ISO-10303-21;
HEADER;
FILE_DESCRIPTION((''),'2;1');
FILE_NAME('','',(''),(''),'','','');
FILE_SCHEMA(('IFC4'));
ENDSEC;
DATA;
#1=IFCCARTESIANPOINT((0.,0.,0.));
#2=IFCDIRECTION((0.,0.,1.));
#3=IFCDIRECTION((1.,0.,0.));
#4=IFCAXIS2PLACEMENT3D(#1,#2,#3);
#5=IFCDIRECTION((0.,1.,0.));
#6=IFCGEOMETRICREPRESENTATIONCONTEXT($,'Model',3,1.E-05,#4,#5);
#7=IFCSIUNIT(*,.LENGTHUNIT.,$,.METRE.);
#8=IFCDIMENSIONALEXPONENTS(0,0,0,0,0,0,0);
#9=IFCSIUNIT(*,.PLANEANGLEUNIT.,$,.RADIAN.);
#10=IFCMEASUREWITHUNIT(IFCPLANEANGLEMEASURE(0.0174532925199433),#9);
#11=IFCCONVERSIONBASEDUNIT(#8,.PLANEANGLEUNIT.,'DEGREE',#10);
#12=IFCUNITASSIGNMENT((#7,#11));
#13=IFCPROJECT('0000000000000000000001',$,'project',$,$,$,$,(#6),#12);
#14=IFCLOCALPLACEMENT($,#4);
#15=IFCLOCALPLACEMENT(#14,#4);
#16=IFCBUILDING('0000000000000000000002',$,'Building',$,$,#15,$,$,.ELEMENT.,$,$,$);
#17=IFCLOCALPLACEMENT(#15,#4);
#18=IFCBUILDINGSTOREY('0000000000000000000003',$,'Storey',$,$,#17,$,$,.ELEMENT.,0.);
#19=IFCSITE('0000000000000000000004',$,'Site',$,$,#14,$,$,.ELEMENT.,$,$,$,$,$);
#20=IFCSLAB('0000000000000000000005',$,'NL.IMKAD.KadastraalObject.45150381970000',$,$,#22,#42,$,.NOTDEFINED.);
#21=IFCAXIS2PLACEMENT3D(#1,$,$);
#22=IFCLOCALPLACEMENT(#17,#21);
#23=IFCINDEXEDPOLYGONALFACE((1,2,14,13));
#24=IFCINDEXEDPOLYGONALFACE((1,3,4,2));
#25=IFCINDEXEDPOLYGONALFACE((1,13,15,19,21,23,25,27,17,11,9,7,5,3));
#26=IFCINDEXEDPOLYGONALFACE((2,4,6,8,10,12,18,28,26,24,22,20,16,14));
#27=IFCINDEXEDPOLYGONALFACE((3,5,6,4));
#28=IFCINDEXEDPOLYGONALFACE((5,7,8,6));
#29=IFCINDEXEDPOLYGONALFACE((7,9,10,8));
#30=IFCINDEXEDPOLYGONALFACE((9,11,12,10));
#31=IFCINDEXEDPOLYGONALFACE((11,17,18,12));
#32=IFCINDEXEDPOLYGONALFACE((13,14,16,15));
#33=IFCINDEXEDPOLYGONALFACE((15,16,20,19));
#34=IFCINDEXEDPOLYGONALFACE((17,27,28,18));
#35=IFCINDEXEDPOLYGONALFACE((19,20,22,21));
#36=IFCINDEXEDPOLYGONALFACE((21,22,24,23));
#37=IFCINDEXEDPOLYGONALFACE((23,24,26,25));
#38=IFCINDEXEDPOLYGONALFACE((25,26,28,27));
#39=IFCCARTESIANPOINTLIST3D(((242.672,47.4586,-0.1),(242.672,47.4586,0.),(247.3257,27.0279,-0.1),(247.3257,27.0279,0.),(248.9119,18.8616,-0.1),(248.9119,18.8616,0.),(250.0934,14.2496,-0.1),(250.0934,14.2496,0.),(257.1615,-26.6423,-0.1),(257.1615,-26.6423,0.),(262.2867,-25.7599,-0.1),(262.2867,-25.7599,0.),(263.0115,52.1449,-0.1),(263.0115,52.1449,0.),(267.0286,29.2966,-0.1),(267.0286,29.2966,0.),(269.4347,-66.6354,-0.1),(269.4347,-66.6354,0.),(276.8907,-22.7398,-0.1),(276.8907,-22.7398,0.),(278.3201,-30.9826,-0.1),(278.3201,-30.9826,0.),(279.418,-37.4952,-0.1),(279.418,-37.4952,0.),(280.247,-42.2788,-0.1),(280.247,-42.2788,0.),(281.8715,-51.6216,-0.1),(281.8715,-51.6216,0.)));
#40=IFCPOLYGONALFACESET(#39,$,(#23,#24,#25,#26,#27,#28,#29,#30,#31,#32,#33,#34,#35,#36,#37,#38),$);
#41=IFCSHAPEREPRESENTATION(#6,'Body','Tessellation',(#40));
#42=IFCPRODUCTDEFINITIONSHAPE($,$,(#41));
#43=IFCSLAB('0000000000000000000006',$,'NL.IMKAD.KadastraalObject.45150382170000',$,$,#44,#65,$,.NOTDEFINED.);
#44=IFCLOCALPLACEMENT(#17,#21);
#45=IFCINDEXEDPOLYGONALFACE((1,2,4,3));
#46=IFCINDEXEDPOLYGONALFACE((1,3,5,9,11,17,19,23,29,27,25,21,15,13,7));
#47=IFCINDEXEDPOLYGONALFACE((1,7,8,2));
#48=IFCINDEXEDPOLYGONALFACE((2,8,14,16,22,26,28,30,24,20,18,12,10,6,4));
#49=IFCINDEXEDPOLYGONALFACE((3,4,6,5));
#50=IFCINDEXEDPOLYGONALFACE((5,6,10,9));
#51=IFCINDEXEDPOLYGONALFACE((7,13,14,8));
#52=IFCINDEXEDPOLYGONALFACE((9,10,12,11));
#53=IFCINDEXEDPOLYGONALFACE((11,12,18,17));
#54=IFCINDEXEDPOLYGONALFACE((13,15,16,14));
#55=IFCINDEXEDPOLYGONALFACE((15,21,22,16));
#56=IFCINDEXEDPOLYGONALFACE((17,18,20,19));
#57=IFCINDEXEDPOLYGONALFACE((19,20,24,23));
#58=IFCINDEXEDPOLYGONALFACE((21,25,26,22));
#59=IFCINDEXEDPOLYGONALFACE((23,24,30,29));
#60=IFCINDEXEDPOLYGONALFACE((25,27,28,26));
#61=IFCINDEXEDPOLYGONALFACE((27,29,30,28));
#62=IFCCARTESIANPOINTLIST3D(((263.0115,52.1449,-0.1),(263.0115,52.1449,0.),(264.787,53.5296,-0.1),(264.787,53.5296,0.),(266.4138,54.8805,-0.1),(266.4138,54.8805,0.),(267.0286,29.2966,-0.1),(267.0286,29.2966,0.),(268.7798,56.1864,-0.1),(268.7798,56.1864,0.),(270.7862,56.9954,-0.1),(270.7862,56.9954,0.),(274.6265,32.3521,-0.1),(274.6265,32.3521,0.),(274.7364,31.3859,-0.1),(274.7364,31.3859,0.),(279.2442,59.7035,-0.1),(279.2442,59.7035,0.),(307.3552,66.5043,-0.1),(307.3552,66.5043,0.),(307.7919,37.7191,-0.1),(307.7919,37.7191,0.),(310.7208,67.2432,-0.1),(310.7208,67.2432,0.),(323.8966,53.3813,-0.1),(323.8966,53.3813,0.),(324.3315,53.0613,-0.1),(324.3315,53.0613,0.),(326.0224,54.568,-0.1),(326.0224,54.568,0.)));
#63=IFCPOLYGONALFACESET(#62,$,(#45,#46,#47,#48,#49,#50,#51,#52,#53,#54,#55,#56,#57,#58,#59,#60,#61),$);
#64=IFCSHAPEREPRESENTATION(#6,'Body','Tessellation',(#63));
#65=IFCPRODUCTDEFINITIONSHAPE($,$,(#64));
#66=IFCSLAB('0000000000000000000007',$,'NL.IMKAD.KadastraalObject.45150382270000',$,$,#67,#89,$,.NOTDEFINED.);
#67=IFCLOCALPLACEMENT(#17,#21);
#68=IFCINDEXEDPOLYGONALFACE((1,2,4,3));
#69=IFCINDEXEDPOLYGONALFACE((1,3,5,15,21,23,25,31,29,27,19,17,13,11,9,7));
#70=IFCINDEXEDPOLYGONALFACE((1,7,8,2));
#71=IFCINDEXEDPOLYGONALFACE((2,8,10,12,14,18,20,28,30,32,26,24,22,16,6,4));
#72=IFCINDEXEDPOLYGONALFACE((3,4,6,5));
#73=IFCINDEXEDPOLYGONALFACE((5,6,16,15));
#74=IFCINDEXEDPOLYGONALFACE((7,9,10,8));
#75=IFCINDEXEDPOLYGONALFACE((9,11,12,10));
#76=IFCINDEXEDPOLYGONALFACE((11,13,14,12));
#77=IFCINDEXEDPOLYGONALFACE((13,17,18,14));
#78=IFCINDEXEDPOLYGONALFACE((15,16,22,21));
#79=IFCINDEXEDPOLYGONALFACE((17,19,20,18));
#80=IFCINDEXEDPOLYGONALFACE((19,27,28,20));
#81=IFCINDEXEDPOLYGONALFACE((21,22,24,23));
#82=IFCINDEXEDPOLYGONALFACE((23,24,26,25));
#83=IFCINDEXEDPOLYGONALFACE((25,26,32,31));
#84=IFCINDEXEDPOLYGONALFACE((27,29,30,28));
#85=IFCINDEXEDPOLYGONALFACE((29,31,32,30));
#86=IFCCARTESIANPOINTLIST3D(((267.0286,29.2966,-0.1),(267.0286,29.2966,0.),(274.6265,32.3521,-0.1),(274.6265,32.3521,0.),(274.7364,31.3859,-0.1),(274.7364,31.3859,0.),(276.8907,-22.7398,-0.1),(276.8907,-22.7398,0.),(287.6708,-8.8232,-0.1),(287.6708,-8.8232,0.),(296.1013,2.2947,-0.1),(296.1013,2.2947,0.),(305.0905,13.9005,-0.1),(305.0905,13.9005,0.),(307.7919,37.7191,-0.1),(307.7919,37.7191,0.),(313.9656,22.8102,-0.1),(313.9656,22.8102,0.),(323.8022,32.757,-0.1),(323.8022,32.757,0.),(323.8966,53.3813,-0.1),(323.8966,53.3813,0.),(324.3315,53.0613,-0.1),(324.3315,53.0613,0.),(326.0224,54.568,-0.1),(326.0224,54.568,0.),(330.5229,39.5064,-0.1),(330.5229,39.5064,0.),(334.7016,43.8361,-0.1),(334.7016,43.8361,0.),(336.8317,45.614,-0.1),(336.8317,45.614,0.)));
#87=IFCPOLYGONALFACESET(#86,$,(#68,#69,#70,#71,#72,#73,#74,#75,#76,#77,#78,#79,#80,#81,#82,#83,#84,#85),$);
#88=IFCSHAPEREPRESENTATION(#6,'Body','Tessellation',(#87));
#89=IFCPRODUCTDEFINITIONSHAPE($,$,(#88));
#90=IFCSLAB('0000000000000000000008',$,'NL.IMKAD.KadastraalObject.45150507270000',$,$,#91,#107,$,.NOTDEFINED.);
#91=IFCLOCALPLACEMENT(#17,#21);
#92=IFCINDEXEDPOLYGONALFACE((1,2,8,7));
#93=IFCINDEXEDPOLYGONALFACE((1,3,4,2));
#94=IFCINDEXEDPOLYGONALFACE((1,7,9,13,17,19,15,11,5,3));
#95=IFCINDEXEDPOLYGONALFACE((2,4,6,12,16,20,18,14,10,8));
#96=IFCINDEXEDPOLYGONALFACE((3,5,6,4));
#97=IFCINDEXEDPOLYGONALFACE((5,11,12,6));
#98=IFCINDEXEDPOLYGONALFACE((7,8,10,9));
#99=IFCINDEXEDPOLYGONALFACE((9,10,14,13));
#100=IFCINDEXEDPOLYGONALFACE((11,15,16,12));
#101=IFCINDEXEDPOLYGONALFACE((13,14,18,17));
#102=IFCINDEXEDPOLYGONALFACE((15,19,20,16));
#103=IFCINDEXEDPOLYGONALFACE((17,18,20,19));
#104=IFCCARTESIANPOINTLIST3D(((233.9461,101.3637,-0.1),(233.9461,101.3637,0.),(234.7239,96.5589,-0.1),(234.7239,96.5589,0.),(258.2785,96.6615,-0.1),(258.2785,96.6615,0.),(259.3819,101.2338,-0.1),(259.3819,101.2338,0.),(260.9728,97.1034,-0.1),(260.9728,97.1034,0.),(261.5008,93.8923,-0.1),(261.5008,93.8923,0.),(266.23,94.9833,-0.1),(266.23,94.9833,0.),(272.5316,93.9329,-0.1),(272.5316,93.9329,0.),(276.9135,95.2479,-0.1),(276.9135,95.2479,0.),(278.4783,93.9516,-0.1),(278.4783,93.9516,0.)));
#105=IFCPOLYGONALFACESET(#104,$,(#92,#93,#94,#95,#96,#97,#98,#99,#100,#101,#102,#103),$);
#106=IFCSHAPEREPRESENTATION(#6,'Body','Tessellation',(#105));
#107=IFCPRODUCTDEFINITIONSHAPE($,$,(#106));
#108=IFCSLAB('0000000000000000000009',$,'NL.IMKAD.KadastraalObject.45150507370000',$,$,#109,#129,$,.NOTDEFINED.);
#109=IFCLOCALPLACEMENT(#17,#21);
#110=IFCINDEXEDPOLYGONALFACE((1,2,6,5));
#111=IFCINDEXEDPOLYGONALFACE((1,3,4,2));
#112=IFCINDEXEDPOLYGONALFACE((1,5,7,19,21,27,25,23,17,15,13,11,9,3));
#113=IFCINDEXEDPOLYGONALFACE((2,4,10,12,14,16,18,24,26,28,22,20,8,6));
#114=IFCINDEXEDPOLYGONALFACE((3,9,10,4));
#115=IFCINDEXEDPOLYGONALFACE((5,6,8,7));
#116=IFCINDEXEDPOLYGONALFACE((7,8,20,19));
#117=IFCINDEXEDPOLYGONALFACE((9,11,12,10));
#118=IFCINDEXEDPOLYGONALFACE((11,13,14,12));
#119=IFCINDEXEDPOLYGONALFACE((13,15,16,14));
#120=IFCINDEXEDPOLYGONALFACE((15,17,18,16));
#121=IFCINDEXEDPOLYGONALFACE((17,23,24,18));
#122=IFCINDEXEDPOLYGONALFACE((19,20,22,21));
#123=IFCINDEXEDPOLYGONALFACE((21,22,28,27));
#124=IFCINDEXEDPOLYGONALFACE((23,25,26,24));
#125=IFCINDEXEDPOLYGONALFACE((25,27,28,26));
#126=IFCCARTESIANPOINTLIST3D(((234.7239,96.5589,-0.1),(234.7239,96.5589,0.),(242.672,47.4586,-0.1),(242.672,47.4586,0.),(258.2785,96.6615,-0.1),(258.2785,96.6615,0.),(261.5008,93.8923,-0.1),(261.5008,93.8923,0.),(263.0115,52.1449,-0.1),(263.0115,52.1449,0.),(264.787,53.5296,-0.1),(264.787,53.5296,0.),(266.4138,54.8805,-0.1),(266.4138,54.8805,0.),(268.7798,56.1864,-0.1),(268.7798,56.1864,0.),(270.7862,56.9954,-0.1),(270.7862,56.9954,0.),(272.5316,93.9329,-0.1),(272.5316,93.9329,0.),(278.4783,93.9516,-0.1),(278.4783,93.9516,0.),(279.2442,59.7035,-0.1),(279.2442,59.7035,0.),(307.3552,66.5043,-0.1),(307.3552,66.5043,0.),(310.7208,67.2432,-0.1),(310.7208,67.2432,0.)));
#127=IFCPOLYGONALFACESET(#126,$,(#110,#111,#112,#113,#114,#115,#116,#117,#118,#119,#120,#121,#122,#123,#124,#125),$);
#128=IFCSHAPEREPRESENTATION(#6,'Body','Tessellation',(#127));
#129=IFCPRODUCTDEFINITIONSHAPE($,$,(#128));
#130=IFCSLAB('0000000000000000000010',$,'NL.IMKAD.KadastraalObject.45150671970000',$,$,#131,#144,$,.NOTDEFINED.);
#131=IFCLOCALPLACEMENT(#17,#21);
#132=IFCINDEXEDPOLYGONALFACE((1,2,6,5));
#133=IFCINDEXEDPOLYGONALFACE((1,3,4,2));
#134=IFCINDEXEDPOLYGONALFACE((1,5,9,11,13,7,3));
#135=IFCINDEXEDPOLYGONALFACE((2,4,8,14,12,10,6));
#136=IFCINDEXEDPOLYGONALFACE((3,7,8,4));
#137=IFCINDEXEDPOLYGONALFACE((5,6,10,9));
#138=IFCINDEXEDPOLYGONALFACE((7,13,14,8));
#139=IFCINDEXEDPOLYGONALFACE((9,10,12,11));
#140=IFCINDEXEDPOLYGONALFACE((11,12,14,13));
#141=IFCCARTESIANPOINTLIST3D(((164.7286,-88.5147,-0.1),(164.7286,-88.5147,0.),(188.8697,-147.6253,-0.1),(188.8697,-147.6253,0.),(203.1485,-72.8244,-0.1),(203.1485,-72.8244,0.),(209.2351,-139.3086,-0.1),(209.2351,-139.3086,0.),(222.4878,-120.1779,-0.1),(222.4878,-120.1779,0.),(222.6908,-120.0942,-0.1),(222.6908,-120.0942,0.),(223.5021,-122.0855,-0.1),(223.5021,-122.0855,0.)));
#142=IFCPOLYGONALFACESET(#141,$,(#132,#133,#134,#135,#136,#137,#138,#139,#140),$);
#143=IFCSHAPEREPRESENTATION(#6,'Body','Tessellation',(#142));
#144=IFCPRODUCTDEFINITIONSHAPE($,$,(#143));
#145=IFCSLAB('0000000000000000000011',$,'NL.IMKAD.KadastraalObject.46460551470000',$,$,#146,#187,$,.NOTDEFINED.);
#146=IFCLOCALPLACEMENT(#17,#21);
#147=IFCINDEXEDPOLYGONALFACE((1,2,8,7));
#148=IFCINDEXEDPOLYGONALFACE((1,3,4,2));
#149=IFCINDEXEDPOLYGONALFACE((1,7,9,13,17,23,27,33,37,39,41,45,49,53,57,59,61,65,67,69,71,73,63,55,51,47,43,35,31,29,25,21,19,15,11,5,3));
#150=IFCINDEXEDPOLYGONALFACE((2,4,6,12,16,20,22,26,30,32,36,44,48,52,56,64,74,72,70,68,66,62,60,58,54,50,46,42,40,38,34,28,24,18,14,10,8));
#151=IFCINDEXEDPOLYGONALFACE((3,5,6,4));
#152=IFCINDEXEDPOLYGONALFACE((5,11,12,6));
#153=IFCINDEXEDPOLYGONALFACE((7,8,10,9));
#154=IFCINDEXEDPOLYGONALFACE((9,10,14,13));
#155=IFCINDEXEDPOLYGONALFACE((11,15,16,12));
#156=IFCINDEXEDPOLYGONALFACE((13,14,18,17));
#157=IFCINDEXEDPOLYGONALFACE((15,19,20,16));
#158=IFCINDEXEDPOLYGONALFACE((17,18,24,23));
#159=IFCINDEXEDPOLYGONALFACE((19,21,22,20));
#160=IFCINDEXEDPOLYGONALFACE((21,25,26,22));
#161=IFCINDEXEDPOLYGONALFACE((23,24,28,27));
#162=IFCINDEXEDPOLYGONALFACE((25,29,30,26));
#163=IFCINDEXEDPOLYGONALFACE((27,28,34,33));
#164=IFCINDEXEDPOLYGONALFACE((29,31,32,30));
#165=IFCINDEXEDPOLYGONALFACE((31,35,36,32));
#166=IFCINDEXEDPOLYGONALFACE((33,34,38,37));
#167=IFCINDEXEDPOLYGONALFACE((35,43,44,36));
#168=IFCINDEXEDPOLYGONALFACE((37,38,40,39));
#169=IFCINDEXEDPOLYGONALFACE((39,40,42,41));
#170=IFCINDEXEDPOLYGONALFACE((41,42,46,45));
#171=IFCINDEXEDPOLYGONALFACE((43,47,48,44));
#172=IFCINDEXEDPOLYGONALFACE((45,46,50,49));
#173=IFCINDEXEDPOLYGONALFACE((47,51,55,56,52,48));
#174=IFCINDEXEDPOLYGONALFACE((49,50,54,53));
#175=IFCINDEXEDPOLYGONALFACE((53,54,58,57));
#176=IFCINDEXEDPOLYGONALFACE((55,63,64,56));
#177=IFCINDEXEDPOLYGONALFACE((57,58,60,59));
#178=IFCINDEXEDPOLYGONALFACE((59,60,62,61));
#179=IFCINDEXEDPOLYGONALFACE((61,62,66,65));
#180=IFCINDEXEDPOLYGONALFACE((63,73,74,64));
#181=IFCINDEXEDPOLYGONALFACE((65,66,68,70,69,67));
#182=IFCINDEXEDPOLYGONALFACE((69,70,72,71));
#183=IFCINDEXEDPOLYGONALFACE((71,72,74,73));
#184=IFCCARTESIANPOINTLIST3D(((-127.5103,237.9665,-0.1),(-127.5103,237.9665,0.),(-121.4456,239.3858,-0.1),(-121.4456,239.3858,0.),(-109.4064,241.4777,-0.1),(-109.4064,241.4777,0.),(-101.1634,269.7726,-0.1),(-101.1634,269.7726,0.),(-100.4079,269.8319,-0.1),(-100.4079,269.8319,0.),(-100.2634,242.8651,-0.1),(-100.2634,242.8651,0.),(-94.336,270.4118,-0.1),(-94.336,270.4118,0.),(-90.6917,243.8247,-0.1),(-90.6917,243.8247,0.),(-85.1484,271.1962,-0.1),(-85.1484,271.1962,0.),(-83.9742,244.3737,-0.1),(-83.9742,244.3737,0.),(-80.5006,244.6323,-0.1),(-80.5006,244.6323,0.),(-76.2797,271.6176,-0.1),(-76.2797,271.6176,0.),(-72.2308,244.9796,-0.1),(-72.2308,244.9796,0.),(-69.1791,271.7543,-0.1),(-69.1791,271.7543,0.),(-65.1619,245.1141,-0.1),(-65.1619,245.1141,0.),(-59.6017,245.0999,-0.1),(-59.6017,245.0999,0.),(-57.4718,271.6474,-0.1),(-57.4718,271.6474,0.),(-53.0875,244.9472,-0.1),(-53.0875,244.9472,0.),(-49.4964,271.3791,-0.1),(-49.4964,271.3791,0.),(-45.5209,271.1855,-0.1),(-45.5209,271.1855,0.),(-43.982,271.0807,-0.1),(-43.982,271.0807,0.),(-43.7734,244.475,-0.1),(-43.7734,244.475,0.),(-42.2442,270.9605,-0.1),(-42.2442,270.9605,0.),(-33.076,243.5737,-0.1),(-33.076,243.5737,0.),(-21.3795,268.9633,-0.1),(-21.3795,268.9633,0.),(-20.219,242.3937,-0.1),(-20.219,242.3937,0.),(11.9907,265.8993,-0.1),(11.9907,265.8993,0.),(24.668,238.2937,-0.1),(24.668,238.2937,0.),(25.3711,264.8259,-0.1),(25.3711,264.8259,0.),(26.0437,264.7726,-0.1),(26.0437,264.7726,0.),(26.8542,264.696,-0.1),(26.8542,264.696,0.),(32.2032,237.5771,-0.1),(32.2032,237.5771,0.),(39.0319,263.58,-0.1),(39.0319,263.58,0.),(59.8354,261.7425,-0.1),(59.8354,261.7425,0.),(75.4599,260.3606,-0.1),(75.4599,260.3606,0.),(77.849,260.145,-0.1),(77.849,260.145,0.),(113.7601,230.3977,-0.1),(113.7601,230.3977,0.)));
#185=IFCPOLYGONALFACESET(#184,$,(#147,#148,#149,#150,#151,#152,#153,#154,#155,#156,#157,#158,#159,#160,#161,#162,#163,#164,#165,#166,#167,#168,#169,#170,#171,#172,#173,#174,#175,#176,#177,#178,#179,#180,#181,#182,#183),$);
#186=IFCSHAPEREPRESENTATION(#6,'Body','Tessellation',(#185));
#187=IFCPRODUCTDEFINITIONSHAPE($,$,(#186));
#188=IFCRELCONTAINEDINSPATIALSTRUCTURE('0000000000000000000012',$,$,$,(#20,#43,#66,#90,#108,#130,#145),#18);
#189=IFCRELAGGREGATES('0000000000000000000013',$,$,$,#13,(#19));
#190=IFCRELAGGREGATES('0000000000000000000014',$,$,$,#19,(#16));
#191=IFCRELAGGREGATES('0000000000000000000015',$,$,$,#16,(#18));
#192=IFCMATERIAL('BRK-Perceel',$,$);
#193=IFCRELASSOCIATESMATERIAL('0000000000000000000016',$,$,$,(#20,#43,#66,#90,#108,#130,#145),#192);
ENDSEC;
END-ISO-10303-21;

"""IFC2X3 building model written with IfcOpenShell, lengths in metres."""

from ifc_helpers import new_model, entity, si_unit, converted_unit, direction, frame, origin_with_axes, place, context, project, spatial, polyline, outline, extrude, material, element, save


model = new_model("IFC2X3")

# Units and contexts
model_context = context("Model", 3, precision=1e-05, world=origin_with_axes(), true_north=direction((0.0, 1.0, 0.0)))
ifc_project = project(units=[si_unit("LENGTHUNIT", "METRE"), converted_unit("PLANEANGLEUNIT", "DEGREE", entity("IfcPlaneAngleMeasure", 0.0174532925199433), si_unit("PLANEANGLEUNIT", "RADIAN"), dimensions=[0, 0, 0, 0, 0, 0, 0])], contexts=[model_context])

# Site, building, storey
site_placement = place(None, origin_with_axes())
site = spatial("IfcSite", under=ifc_project, at=site_placement, Name="Site", CompositionType="ELEMENT")
building_placement = place(site_placement, origin_with_axes())
building = spatial("IfcBuilding", under=site, at=building_placement, Name="Building", CompositionType="ELEMENT")
storey_placement = place(building_placement, origin_with_axes())
storey = spatial("IfcBuildingStorey", under=building, at=storey_placement, Name="Storey", CompositionType="ELEMENT", Elevation=0.0)

# Slabs
ifc_material = material(Name="BRK-Perceel")
slab_1_placement = place(storey_placement, frame((0.0, 0.0, -0.1), z_axis=(0.0, 0.0, 1.0), x_axis=(1.0, 0.0, 0.0)))
element("IfcSlab", 1, at=slab_1_placement, inside=storey, material=ifc_material, Name="NL.IMKAD.KadastraalObject.45150381970000", PredefinedType="NOTDEFINED", context=model_context, shape_type="SweptSolid", body=[
    extrude(outline(polyline([(262.2867, -25.7599), (257.1615, -26.6423), (250.0934, 14.2496), (248.9119, 18.8616), (247.3257, 27.0279), (242.672, 47.4586), (263.0115, 52.1449), (267.0286, 29.2966), (276.8907, -22.7398), (278.3201, -30.9826), (279.418, -37.4952), (280.247, -42.2788), (281.8715, -51.6216), (269.4347, -66.6354), (262.2867, -25.7599)])), origin_with_axes(), (0.0, 0.0, 1.0), 0.1),
])
slab_2_placement = place(storey_placement, frame((0.0, 0.0, -0.1), z_axis=(0.0, 0.0, 1.0), x_axis=(1.0, 0.0, 0.0)))
element("IfcSlab", 2, at=slab_2_placement, inside=storey, material=ifc_material, Name="NL.IMKAD.KadastraalObject.45150382170000", PredefinedType="NOTDEFINED", context=model_context, shape_type="SweptSolid", body=[
    extrude(outline(polyline([(324.3315, 53.0613), (323.8966, 53.3813), (307.7919, 37.7191), (274.7364, 31.3859), (274.6265, 32.3521), (267.0286, 29.2966), (263.0115, 52.1449), (264.787, 53.5296), (266.4138, 54.8805), (268.7798, 56.1864), (270.7862, 56.9954), (279.2442, 59.7035), (307.3552, 66.5043), (310.7208, 67.2432), (326.0224, 54.568), (324.3315, 53.0613)])), origin_with_axes(), (0.0, 0.0, 1.0), 0.1),
])
slab_3_placement = place(storey_placement, frame((0.0, 0.0, -0.1), z_axis=(0.0, 0.0, 1.0), x_axis=(1.0, 0.0, 0.0)))
element("IfcSlab", 3, at=slab_3_placement, inside=storey, material=ifc_material, Name="NL.IMKAD.KadastraalObject.45150382270000", PredefinedType="NOTDEFINED", context=model_context, shape_type="SweptSolid", body=[
    extrude(outline(polyline([(334.7016, 43.8361), (330.5229, 39.5064), (323.8022, 32.757), (313.9656, 22.8102), (305.0905, 13.9005), (296.1013, 2.2947), (287.6708, -8.8232), (276.8907, -22.7398), (267.0286, 29.2966), (274.6265, 32.3521), (274.7364, 31.3859), (307.7919, 37.7191), (323.8966, 53.3813), (324.3315, 53.0613), (326.0224, 54.568), (336.8317, 45.614), (334.7016, 43.8361)])), origin_with_axes(), (0.0, 0.0, 1.0), 0.1),
])
slab_4_placement = place(storey_placement, frame((0.0, 0.0, -0.1), z_axis=(0.0, 0.0, 1.0), x_axis=(1.0, 0.0, 0.0)))
element("IfcSlab", 4, at=slab_4_placement, inside=storey, material=ifc_material, Name="NL.IMKAD.KadastraalObject.45150507270000", PredefinedType="NOTDEFINED", context=model_context, shape_type="SweptSolid", body=[
    extrude(outline(polyline([(272.5316, 93.9329), (261.5008, 93.8923), (258.2785, 96.6615), (234.7239, 96.5589), (233.9461, 101.3637), (259.3819, 101.2338), (260.9728, 97.1034), (266.23, 94.9833), (276.9135, 95.2479), (278.4783, 93.9516), (272.5316, 93.9329)])), origin_with_axes(), (0.0, 0.0, 1.0), 0.1),
])
slab_5_placement = place(storey_placement, frame((0.0, 0.0, -0.1), z_axis=(0.0, 0.0, 1.0), x_axis=(1.0, 0.0, 0.0)))
element("IfcSlab", 5, at=slab_5_placement, inside=storey, material=ifc_material, Name="NL.IMKAD.KadastraalObject.45150507370000", PredefinedType="NOTDEFINED", context=model_context, shape_type="SweptSolid", body=[
    extrude(outline(polyline([(307.3552, 66.5043), (279.2442, 59.7035), (270.7862, 56.9954), (268.7798, 56.1864), (266.4138, 54.8805), (264.787, 53.5296), (263.0115, 52.1449), (242.672, 47.4586), (234.7239, 96.5589), (258.2785, 96.6615), (261.5008, 93.8923), (272.5316, 93.9329), (278.4783, 93.9516), (310.7208, 67.2432), (307.3552, 66.5043)])), origin_with_axes(), (0.0, 0.0, 1.0), 0.1),
])
slab_6_placement = place(storey_placement, frame((0.0, 0.0, -0.1), z_axis=(0.0, 0.0, 1.0), x_axis=(1.0, 0.0, 0.0)))
element("IfcSlab", 6, at=slab_6_placement, inside=storey, material=ifc_material, Name="NL.IMKAD.KadastraalObject.45150671970000", PredefinedType="NOTDEFINED", context=model_context, shape_type="SweptSolid", body=[
    extrude(outline(polyline([(188.8697, -147.6253), (164.7286, -88.5147), (203.1485, -72.8244), (222.4878, -120.1779), (222.6908, -120.0942), (223.5021, -122.0855), (209.2351, -139.3086), (188.8697, -147.6253)])), origin_with_axes(), (0.0, 0.0, 1.0), 0.1),
])
slab_7_placement = place(storey_placement, frame((0.0, 0.0, -0.1), z_axis=(0.0, 0.0, 1.0), x_axis=(1.0, 0.0, 0.0)))
element("IfcSlab", 7, at=slab_7_placement, inside=storey, material=ifc_material, Name="NL.IMKAD.KadastraalObject.46460551470000", PredefinedType="NOTDEFINED", context=model_context, shape_type="SweptSolid", body=[
    extrude(outline(polyline([(-100.4079, 269.8319), (-94.336, 270.4118), (-85.1484, 271.1962), (-76.2797, 271.6176), (-69.1791, 271.7543), (-57.4718, 271.6474), (-49.4964, 271.3791), (-45.5209, 271.1855), (-43.982, 271.0807), (-42.2442, 270.9605), (-21.3795, 268.9633), (11.9907, 265.8993), (25.3711, 264.8259), (26.0437, 264.7726), (26.8542, 264.696), (39.0319, 263.58), (59.8354, 261.7425), (75.4599, 260.3606), (77.849, 260.145), (113.7601, 230.3977), (32.2032, 237.5771), (24.668, 238.2937), (-20.219, 242.3937), (-33.076, 243.5737), (-43.7734, 244.475), (-53.0875, 244.9472), (-59.6017, 245.0999), (-65.1619, 245.1141), (-72.2308, 244.9796), (-80.5006, 244.6323), (-83.9742, 244.3737), (-90.6917, 243.8247), (-100.2634, 242.8651), (-109.4064, 241.4777), (-121.4456, 239.3858), (-127.5103, 237.9665), (-101.1634, 269.7726), (-100.4079, 269.8319)])), origin_with_axes(), (0.0, 0.0, 1.0), 0.1),
])

save(model, "model.ifc")
